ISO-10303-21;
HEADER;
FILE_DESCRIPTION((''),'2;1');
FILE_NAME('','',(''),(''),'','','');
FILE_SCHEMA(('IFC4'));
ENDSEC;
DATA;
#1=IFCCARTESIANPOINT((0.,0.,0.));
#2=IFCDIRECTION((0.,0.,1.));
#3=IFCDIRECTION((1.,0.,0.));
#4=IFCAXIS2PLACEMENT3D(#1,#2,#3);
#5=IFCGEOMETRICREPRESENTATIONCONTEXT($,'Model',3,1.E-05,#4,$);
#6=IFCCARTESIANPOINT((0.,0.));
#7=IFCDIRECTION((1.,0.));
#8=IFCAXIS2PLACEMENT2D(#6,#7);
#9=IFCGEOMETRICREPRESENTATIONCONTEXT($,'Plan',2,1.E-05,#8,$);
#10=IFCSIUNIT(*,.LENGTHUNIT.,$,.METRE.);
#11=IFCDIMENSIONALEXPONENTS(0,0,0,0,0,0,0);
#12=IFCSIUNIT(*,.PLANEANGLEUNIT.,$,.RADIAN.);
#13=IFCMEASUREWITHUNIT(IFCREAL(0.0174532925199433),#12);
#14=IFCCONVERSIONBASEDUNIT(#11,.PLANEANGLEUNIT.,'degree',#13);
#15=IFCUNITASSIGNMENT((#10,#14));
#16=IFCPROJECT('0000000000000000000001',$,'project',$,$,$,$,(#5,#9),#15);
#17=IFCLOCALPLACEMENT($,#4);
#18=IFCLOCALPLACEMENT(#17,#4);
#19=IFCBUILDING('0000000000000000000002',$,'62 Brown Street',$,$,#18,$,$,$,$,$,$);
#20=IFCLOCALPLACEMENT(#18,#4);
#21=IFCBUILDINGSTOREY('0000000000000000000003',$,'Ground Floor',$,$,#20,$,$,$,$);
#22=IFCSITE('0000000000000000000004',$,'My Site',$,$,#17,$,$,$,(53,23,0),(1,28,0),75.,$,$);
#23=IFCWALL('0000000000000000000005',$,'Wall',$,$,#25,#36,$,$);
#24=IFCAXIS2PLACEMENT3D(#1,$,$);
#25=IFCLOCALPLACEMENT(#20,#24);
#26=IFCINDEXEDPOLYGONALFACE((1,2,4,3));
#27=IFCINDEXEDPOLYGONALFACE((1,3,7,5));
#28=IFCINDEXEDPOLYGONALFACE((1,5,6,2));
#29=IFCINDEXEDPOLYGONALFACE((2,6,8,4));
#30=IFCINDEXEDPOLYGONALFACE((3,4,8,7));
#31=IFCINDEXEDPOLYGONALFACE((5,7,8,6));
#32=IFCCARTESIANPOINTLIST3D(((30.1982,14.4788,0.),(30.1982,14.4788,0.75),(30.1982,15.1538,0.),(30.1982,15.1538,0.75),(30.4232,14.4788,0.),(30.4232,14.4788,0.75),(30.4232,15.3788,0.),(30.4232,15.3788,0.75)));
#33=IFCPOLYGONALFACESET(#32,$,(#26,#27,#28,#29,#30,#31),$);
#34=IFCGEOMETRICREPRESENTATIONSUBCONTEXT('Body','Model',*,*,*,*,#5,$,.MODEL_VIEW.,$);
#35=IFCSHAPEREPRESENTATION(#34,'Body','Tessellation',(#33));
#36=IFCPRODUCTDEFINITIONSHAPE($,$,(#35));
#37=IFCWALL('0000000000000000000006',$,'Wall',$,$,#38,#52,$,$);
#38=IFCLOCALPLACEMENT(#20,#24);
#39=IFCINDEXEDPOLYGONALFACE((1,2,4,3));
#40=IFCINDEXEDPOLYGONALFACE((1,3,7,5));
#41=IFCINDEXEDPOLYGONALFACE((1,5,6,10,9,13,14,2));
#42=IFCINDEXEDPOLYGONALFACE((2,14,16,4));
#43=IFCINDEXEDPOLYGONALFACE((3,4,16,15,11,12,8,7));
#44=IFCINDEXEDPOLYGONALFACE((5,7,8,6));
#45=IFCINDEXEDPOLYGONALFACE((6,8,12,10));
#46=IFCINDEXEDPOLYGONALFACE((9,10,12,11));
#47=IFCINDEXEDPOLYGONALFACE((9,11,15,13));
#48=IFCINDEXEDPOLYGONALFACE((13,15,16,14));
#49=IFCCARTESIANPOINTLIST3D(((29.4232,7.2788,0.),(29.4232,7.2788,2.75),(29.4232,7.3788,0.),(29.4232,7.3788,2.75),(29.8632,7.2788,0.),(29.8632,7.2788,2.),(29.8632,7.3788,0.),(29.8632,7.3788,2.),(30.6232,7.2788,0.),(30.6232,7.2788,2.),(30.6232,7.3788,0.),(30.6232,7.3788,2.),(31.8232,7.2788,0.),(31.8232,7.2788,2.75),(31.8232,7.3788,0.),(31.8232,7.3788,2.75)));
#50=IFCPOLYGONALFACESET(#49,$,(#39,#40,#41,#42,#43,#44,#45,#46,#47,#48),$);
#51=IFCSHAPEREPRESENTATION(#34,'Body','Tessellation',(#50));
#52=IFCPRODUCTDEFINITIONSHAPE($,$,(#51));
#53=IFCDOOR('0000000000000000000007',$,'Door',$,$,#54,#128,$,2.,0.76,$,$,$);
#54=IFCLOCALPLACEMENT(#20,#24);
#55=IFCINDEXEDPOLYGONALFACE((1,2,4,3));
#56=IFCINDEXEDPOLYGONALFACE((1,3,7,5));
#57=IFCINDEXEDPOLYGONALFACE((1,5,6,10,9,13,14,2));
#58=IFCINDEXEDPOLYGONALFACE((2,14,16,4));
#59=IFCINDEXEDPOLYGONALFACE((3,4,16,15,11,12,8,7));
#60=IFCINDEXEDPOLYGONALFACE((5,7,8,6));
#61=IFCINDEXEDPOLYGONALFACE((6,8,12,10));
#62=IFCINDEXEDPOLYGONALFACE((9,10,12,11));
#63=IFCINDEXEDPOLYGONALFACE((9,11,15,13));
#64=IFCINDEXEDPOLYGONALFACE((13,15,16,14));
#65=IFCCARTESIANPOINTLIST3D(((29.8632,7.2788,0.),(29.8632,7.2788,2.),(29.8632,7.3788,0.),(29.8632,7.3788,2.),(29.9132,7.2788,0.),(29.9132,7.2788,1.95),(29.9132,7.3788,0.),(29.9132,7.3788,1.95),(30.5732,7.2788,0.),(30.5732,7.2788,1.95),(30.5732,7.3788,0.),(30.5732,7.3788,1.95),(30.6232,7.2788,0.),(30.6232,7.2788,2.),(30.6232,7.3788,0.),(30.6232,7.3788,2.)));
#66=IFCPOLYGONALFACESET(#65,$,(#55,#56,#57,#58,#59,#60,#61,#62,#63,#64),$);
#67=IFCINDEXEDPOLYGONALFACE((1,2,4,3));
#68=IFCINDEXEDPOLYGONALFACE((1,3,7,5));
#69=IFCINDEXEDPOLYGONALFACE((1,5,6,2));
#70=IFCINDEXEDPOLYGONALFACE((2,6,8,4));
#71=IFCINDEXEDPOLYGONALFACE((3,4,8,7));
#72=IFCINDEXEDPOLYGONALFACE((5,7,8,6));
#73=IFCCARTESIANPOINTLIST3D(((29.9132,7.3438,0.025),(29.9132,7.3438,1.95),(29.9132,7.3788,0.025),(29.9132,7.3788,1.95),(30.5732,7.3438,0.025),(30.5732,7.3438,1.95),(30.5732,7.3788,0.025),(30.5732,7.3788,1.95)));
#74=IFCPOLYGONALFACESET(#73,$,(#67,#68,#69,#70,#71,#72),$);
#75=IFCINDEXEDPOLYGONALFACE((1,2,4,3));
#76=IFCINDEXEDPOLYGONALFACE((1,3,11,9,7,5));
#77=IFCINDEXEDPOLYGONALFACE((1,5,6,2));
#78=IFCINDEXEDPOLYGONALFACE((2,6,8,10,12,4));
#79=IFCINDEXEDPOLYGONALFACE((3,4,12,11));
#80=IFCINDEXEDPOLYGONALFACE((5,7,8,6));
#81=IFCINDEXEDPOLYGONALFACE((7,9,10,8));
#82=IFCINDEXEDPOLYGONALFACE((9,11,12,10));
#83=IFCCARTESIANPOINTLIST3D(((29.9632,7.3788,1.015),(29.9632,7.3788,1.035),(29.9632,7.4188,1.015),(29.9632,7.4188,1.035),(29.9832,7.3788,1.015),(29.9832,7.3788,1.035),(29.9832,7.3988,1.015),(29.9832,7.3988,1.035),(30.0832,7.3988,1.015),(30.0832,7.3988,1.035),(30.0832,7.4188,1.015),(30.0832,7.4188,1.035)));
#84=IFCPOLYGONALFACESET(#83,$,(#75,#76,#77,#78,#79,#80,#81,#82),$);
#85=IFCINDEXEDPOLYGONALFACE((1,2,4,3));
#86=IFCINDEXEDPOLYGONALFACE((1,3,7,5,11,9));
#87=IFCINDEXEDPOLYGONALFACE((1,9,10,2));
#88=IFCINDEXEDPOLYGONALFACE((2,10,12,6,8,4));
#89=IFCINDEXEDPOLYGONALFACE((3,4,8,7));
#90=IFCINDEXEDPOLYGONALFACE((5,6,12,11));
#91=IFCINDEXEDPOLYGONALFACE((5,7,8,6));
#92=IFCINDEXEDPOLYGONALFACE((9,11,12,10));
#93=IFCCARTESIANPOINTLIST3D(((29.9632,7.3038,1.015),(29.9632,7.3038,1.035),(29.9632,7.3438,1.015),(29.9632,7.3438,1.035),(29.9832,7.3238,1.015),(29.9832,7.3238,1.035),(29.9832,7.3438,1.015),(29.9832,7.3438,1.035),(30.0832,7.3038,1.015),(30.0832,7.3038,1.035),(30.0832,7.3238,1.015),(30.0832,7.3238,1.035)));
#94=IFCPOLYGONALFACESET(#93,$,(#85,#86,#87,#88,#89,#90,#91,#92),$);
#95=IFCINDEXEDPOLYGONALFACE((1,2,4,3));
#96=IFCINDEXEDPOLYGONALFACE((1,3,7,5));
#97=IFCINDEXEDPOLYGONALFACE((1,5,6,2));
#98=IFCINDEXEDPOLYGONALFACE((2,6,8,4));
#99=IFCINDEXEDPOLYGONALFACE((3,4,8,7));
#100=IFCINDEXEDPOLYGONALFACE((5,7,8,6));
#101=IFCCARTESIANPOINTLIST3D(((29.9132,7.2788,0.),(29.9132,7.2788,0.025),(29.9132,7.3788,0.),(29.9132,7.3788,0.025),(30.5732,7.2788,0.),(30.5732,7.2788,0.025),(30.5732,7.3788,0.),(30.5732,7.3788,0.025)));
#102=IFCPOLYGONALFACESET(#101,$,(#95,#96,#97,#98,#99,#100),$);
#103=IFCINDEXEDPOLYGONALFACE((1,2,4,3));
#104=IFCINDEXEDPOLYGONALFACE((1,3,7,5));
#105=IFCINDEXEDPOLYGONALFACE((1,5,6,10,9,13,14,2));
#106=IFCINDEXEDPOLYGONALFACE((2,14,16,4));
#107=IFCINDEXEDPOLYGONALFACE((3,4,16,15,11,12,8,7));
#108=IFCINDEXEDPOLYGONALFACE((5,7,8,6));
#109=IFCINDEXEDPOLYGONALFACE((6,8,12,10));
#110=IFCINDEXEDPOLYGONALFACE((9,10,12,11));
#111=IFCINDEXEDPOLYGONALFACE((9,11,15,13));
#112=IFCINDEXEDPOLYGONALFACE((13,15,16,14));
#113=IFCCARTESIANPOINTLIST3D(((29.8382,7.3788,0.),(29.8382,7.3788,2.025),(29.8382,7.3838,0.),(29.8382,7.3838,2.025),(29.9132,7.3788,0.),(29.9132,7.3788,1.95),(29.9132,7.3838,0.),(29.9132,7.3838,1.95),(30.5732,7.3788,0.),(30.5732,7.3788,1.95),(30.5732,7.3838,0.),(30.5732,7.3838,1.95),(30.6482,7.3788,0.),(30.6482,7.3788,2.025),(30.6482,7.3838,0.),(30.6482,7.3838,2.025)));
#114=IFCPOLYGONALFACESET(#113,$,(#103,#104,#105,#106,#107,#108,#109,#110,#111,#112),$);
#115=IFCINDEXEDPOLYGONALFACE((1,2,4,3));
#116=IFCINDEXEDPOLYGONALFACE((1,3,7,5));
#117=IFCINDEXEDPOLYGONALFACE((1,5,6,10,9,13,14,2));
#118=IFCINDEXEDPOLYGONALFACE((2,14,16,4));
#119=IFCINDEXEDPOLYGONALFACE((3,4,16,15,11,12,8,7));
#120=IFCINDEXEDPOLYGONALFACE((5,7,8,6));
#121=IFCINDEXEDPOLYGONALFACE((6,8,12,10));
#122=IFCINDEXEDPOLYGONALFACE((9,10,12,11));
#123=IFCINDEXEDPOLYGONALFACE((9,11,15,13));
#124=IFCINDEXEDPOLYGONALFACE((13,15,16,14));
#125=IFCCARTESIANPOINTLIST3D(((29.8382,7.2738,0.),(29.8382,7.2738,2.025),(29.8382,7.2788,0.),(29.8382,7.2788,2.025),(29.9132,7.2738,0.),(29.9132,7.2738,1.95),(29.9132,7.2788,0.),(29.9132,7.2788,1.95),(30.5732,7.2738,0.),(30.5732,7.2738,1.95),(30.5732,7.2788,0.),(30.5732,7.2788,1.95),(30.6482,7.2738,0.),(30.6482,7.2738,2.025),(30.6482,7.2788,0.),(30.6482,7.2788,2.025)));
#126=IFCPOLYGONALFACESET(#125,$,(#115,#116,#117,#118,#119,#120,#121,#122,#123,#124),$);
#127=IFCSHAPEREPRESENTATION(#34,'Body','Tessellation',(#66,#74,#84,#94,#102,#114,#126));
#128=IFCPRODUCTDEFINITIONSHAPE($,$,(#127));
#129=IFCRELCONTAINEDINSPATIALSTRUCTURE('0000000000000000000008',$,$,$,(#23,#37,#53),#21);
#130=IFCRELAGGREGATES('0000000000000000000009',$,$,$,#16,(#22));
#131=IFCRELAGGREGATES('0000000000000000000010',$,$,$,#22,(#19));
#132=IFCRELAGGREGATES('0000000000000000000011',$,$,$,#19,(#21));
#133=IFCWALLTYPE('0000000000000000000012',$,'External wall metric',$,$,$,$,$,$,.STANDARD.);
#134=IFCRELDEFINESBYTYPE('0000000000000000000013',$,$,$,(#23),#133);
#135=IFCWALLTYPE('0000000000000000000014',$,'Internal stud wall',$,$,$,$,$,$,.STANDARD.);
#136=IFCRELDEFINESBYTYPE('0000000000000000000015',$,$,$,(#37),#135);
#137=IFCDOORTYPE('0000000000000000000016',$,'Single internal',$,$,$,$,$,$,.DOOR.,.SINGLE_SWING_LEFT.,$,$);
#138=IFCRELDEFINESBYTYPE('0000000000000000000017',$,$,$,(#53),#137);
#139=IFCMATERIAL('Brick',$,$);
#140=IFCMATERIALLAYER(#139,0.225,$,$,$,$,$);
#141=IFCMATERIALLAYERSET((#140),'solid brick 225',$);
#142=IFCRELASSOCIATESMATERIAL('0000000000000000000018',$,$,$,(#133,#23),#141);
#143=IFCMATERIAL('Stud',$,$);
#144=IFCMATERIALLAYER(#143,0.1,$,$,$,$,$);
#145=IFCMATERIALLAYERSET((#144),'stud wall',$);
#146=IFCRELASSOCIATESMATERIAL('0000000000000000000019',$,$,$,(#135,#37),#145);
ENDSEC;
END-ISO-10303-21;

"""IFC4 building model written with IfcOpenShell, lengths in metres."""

from ifc_helpers import new_model, entity, si_unit, converted_unit, frame, origin_with_axes, origin_2d_with_axis, place, context, subcontext, project, spatial, line, indexed_curve, outline, extrude, clip, halfspace, shape, source, transform, mapped, material, layer, layer_set, layer_usage, type_object, type_shapes, element, fill, save


model = new_model("IFC4")

# Units and contexts
model_context = context("Model", 3, precision=1e-05, world=origin_with_axes())
plan_context = context("Plan", 2, precision=1e-05, world=origin_2d_with_axis())
body_context_1 = subcontext(model_context, "Body", "Model", "MODEL_VIEW")
body_context_2 = subcontext(plan_context, "Body", "Plan", "PLAN_VIEW")
ifc_project = project(units=[si_unit("LENGTHUNIT", "METRE"), converted_unit("PLANEANGLEUNIT", "degree", entity("IfcReal", 0.0174532925199433), si_unit("PLANEANGLEUNIT", "RADIAN"), dimensions=[0, 0, 0, 0, 0, 0, 0])], contexts=[model_context, plan_context])

# Site, building, storey
site_placement = place(None, origin_with_axes())
site = spatial("IfcSite", under=ifc_project, at=site_placement, Name="My Site", RefLatitude=(53, 23, 0), RefLongitude=(1, 28, 0), RefElevation=75.0)
building_placement = place(site_placement, origin_with_axes())
building = spatial("IfcBuilding", under=site, at=building_placement, Name="62 Brown Street")
storey_placement = place(building_placement, origin_with_axes())
storey = spatial("IfcBuildingStorey", under=building, at=storey_placement, Name="Ground Floor")

# Shared definitions
ifc_material_1 = material(Name="Brick")
ifc_layer_1 = layer(ifc_material_1, 0.225)
ifc_layer_set_1 = layer_set([ifc_layer_1], Name="solid brick 225")
wall_type_1 = type_object("IfcWallType", Name="External wall metric", PredefinedType="STANDARD", material=ifc_layer_set_1)

# Wall
ifc_layer_usage_1 = layer_usage(ifc_layer_set_1, "AXIS2", "POSITIVE", 0.0)
wall_1_placement = place(storey_placement, frame((30.4232, 14.4788, 0.0), z_axis=(0.0, 0.0, 1.0), x_axis=(0.0, 1.0, 0.0)))
element("IfcWall", 1, at=wall_1_placement, inside=storey, type_object=wall_type_1, material=ifc_layer_usage_1, Name="Wall", context=body_context_1, shape_type="Clipping", body=[
    clip(extrude(outline(indexed_curve([(0.0, 0.0), (0.0, 0.225), (0.9, 0.225), (0.9, 0.0), (0.0, 0.0)], self_intersect=False)), origin_with_axes(), (0.0, 0.0, 1.0), 0.75), halfspace(frame((0.9, 0.0, 0.0), z_axis=(0.707107, 0.707107, 0.0), x_axis=(0.707107, -0.707107, 0.0)), False)),
])

# Wall, opening, door
ifc_material_2 = material(Name="Stud")
ifc_layer_2 = layer(ifc_material_2, 0.1)
ifc_layer_set_2 = layer_set([ifc_layer_2], Name="stud wall")
ifc_layer_usage_2 = layer_usage(ifc_layer_set_2, "AXIS2", "POSITIVE", 0.0)
wall_type_2 = type_object("IfcWallType", Name="Internal stud wall", PredefinedType="STANDARD", material=ifc_layer_set_2)
wall_2_placement = place(storey_placement, frame((31.8232, 7.3788, 0.0), z_axis=(0.0, 0.0, 1.0), x_axis=(-1.0, 0.0, 0.0)))
wall_2 = element("IfcWall", 2, at=wall_2_placement, inside=storey, type_object=wall_type_2, material=ifc_layer_usage_2, Name="Wall", context=body_context_1, shape_type="SweptSolid", body=[
    extrude(outline(indexed_curve([(0.0, 0.0), (0.0, 0.1), (2.4, 0.1), (2.4, 0.0), (0.0, 0.0)], self_intersect=False)), origin_with_axes(), (0.0, 0.0, 1.0), 2.75),
])
shared_shape_1 = source(origin_with_axes(), body_context_1, "Body", "SweptSolid", [
    extrude(outline(indexed_curve([(0.0, 0.0), (0.76, 0.0), (0.76, 2.0), (0.0, 2.0)], segments=[line(1, 2, 3, 4, 1)])), frame((0.0, -0.6, 0.0), z_axis=(0.0, -1.0, 0.0), x_axis=(1.0, 0.0, 0.0)), (0.0, 0.0, -1.0), 1.2),
])
opening_1_placement = place(wall_2_placement, frame((1.2, 0.0, 0.0), z_axis=(0.0, 0.0, 1.0), x_axis=(1.0, 0.0, 0.0)))
opening_1 = element("IfcOpeningElement", 3, at=opening_1_placement, cuts=wall_2, PredefinedType="OPENING", context=body_context_1, shape_type="MappedRepresentation", body=[
    mapped(shared_shape_1, transform((0.0, 0.0, 0.0), x_axis=(1.0, 0.0, 0.0), y_axis=(0.0, 1.0, 0.0), z_axis=(0.0, 0.0, 1.0), scale=1.0)),
])
door_type_1 = type_object("IfcDoorType", Name="Single internal", OperationType="SINGLE_SWING_LEFT", PredefinedType="DOOR")
shared_shape_2 = source(origin_with_axes(), body_context_1, "Body", "SweptSolid", [
    extrude(outline(indexed_curve([(0.0, 0.0), (0.0, 2.0), (0.76, 2.0), (0.76, 0.0), (0.71, 0.0), (0.71, 1.95), (0.05, 1.95), (0.05, 0.0)], segments=[line(1, 2, 3, 4, 5, 6, 7, 8, 1)])), frame((0.0, 0.0, 0.0), z_axis=(0.0, -1.0, 0.0), x_axis=(1.0, 0.0, 0.0)), (0.0, 0.0, -1.0), 0.1),
    extrude(outline(indexed_curve([(0.0, 0.0), (0.66, 0.0), (0.66, 0.035), (0.0, 0.035)], segments=[line(1, 2, 3, 4, 1)])), frame((0.05, 0.0, 0.025), z_axis=(0.0, 0.0, 1.0), x_axis=(1.0, 0.0, 0.0)), (0.0, 0.0, 1.0), 1.925),
    extrude(outline(indexed_curve([(0.0, 0.0), (0.0, -0.04), (-0.12, -0.04), (-0.12, -0.02), (-0.02, -0.02), (-0.02, 0.0)], segments=[line(1, 2, 3, 4, 5, 6, 1)])), frame((0.66, 0.0, 1.015), z_axis=(0.0, 0.0, 1.0), x_axis=(1.0, 0.0, 0.0)), (0.0, 0.0, 1.0), 0.02),
    extrude(outline(indexed_curve([(0.0, 0.0), (0.0, 0.04), (-0.12, 0.04), (-0.12, 0.02), (-0.02, 0.02), (-0.02, 0.0)], segments=[line(1, 2, 3, 4, 5, 6, 1)])), frame((0.66, 0.035, 1.015), z_axis=(0.0, 0.0, 1.0), x_axis=(1.0, 0.0, 0.0)), (0.0, 0.0, 1.0), 0.02),
    extrude(outline(indexed_curve([(0.0, 0.0), (0.66, 0.0), (0.66, 0.1), (0.0, 0.1)], segments=[line(1, 2, 3, 4, 1)])), frame((0.05, 0.0, 0.0), z_axis=(0.0, 0.0, 1.0), x_axis=(1.0, 0.0, 0.0)), (0.0, 0.0, 1.0), 0.025),
    extrude(outline(indexed_curve([(0.0, 0.0), (0.0, 2.025), (0.81, 2.025), (0.81, 0.0), (0.735, 0.0), (0.735, 1.95), (0.075, 1.95), (0.075, 0.0)], segments=[line(1, 2, 3, 4, 5, 6, 7, 8, 1)])), frame((-0.025, -0.005, 0.0), z_axis=(0.0, -1.0, 0.0), x_axis=(1.0, 0.0, 0.0)), (0.0, 0.0, -1.0), 0.005),
    extrude(outline(indexed_curve([(0.0, 0.0), (0.0, 2.025), (0.81, 2.025), (0.81, 0.0), (0.735, 0.0), (0.735, 1.95), (0.075, 1.95), (0.075, 0.0)], segments=[line(1, 2, 3, 4, 5, 6, 7, 8, 1)])), frame((-0.025, 0.1, 0.0), z_axis=(0.0, -1.0, 0.0), x_axis=(1.0, 0.0, 0.0)), (0.0, 0.0, -1.0), 0.005),
])
shared_shape_3 = source(origin_with_axes(), body_context_2, "Body", "Curve2D", [
    entity("IfcIndexedPolyCurve", entity("IfcCartesianPointList2D", [[0.0, 0.0], [0.05, 0.0], [0.05, 0.1], [0.0, 0.1]]), [entity("IfcLineIndex", [1, 2, 3, 4, 1])]),
    entity("IfcIndexedPolyCurve", entity("IfcCartesianPointList2D", [[0.76, 0.0], [0.71, 0.0], [0.71, 0.1], [0.76, 0.1]]), [entity("IfcLineIndex", [1, 2, 3, 4, 1])]),
    entity("IfcTrimmedCurve", entity("IfcEllipse", entity("IfcAxis2Placement2D", entity("IfcCartesianPoint", [0.085, 0.1]), entity("IfcDirection", [1.0, 0.0])), 0.625, 0.66), [entity("IfcCartesianPoint", [0.71, 0.1])], [entity("IfcCartesianPoint", [0.085, 0.76])], True, "CARTESIAN"),
    entity("IfcIndexedPolyCurve", entity("IfcCartesianPointList2D", [[0.05, 0.1], [0.085, 0.1], [0.085, 0.76], [0.05, 0.76]]), [entity("IfcLineIndex", [1, 2, 3, 4, 1])]),
])
type_shapes(door_type_1, [shared_shape_2, shared_shape_3])
door_1_placement = place(opening_1_placement, frame((0.0, 0.0, 0.0), z_axis=(0.0, 0.0, 1.0), x_axis=(1.0, 0.0, 0.0)))
door_1 = element("IfcDoor", 4, at=door_1_placement, inside=storey, type_object=door_type_1, Name="Door", OverallHeight=2.0, OverallWidth=0.76, shapes=[
    shape(body_context_1, "Body", "MappedRepresentation", [mapped(shared_shape_2, transform((0.0, 0.0, 0.0), x_axis=(1.0, 0.0, 0.0), y_axis=(0.0, 1.0, 0.0), z_axis=(0.0, 0.0, 1.0), scale=1.0))]),
    shape(body_context_2, "Body", "MappedRepresentation", [mapped(shared_shape_3, transform((0.0, 0.0, 0.0), x_axis=(1.0, 0.0, 0.0), y_axis=(0.0, 1.0, 0.0), z_axis=(0.0, 0.0, 1.0), scale=1.0))]),
])
fill(opening_1, door_1)

save(model, "model.ifc")
